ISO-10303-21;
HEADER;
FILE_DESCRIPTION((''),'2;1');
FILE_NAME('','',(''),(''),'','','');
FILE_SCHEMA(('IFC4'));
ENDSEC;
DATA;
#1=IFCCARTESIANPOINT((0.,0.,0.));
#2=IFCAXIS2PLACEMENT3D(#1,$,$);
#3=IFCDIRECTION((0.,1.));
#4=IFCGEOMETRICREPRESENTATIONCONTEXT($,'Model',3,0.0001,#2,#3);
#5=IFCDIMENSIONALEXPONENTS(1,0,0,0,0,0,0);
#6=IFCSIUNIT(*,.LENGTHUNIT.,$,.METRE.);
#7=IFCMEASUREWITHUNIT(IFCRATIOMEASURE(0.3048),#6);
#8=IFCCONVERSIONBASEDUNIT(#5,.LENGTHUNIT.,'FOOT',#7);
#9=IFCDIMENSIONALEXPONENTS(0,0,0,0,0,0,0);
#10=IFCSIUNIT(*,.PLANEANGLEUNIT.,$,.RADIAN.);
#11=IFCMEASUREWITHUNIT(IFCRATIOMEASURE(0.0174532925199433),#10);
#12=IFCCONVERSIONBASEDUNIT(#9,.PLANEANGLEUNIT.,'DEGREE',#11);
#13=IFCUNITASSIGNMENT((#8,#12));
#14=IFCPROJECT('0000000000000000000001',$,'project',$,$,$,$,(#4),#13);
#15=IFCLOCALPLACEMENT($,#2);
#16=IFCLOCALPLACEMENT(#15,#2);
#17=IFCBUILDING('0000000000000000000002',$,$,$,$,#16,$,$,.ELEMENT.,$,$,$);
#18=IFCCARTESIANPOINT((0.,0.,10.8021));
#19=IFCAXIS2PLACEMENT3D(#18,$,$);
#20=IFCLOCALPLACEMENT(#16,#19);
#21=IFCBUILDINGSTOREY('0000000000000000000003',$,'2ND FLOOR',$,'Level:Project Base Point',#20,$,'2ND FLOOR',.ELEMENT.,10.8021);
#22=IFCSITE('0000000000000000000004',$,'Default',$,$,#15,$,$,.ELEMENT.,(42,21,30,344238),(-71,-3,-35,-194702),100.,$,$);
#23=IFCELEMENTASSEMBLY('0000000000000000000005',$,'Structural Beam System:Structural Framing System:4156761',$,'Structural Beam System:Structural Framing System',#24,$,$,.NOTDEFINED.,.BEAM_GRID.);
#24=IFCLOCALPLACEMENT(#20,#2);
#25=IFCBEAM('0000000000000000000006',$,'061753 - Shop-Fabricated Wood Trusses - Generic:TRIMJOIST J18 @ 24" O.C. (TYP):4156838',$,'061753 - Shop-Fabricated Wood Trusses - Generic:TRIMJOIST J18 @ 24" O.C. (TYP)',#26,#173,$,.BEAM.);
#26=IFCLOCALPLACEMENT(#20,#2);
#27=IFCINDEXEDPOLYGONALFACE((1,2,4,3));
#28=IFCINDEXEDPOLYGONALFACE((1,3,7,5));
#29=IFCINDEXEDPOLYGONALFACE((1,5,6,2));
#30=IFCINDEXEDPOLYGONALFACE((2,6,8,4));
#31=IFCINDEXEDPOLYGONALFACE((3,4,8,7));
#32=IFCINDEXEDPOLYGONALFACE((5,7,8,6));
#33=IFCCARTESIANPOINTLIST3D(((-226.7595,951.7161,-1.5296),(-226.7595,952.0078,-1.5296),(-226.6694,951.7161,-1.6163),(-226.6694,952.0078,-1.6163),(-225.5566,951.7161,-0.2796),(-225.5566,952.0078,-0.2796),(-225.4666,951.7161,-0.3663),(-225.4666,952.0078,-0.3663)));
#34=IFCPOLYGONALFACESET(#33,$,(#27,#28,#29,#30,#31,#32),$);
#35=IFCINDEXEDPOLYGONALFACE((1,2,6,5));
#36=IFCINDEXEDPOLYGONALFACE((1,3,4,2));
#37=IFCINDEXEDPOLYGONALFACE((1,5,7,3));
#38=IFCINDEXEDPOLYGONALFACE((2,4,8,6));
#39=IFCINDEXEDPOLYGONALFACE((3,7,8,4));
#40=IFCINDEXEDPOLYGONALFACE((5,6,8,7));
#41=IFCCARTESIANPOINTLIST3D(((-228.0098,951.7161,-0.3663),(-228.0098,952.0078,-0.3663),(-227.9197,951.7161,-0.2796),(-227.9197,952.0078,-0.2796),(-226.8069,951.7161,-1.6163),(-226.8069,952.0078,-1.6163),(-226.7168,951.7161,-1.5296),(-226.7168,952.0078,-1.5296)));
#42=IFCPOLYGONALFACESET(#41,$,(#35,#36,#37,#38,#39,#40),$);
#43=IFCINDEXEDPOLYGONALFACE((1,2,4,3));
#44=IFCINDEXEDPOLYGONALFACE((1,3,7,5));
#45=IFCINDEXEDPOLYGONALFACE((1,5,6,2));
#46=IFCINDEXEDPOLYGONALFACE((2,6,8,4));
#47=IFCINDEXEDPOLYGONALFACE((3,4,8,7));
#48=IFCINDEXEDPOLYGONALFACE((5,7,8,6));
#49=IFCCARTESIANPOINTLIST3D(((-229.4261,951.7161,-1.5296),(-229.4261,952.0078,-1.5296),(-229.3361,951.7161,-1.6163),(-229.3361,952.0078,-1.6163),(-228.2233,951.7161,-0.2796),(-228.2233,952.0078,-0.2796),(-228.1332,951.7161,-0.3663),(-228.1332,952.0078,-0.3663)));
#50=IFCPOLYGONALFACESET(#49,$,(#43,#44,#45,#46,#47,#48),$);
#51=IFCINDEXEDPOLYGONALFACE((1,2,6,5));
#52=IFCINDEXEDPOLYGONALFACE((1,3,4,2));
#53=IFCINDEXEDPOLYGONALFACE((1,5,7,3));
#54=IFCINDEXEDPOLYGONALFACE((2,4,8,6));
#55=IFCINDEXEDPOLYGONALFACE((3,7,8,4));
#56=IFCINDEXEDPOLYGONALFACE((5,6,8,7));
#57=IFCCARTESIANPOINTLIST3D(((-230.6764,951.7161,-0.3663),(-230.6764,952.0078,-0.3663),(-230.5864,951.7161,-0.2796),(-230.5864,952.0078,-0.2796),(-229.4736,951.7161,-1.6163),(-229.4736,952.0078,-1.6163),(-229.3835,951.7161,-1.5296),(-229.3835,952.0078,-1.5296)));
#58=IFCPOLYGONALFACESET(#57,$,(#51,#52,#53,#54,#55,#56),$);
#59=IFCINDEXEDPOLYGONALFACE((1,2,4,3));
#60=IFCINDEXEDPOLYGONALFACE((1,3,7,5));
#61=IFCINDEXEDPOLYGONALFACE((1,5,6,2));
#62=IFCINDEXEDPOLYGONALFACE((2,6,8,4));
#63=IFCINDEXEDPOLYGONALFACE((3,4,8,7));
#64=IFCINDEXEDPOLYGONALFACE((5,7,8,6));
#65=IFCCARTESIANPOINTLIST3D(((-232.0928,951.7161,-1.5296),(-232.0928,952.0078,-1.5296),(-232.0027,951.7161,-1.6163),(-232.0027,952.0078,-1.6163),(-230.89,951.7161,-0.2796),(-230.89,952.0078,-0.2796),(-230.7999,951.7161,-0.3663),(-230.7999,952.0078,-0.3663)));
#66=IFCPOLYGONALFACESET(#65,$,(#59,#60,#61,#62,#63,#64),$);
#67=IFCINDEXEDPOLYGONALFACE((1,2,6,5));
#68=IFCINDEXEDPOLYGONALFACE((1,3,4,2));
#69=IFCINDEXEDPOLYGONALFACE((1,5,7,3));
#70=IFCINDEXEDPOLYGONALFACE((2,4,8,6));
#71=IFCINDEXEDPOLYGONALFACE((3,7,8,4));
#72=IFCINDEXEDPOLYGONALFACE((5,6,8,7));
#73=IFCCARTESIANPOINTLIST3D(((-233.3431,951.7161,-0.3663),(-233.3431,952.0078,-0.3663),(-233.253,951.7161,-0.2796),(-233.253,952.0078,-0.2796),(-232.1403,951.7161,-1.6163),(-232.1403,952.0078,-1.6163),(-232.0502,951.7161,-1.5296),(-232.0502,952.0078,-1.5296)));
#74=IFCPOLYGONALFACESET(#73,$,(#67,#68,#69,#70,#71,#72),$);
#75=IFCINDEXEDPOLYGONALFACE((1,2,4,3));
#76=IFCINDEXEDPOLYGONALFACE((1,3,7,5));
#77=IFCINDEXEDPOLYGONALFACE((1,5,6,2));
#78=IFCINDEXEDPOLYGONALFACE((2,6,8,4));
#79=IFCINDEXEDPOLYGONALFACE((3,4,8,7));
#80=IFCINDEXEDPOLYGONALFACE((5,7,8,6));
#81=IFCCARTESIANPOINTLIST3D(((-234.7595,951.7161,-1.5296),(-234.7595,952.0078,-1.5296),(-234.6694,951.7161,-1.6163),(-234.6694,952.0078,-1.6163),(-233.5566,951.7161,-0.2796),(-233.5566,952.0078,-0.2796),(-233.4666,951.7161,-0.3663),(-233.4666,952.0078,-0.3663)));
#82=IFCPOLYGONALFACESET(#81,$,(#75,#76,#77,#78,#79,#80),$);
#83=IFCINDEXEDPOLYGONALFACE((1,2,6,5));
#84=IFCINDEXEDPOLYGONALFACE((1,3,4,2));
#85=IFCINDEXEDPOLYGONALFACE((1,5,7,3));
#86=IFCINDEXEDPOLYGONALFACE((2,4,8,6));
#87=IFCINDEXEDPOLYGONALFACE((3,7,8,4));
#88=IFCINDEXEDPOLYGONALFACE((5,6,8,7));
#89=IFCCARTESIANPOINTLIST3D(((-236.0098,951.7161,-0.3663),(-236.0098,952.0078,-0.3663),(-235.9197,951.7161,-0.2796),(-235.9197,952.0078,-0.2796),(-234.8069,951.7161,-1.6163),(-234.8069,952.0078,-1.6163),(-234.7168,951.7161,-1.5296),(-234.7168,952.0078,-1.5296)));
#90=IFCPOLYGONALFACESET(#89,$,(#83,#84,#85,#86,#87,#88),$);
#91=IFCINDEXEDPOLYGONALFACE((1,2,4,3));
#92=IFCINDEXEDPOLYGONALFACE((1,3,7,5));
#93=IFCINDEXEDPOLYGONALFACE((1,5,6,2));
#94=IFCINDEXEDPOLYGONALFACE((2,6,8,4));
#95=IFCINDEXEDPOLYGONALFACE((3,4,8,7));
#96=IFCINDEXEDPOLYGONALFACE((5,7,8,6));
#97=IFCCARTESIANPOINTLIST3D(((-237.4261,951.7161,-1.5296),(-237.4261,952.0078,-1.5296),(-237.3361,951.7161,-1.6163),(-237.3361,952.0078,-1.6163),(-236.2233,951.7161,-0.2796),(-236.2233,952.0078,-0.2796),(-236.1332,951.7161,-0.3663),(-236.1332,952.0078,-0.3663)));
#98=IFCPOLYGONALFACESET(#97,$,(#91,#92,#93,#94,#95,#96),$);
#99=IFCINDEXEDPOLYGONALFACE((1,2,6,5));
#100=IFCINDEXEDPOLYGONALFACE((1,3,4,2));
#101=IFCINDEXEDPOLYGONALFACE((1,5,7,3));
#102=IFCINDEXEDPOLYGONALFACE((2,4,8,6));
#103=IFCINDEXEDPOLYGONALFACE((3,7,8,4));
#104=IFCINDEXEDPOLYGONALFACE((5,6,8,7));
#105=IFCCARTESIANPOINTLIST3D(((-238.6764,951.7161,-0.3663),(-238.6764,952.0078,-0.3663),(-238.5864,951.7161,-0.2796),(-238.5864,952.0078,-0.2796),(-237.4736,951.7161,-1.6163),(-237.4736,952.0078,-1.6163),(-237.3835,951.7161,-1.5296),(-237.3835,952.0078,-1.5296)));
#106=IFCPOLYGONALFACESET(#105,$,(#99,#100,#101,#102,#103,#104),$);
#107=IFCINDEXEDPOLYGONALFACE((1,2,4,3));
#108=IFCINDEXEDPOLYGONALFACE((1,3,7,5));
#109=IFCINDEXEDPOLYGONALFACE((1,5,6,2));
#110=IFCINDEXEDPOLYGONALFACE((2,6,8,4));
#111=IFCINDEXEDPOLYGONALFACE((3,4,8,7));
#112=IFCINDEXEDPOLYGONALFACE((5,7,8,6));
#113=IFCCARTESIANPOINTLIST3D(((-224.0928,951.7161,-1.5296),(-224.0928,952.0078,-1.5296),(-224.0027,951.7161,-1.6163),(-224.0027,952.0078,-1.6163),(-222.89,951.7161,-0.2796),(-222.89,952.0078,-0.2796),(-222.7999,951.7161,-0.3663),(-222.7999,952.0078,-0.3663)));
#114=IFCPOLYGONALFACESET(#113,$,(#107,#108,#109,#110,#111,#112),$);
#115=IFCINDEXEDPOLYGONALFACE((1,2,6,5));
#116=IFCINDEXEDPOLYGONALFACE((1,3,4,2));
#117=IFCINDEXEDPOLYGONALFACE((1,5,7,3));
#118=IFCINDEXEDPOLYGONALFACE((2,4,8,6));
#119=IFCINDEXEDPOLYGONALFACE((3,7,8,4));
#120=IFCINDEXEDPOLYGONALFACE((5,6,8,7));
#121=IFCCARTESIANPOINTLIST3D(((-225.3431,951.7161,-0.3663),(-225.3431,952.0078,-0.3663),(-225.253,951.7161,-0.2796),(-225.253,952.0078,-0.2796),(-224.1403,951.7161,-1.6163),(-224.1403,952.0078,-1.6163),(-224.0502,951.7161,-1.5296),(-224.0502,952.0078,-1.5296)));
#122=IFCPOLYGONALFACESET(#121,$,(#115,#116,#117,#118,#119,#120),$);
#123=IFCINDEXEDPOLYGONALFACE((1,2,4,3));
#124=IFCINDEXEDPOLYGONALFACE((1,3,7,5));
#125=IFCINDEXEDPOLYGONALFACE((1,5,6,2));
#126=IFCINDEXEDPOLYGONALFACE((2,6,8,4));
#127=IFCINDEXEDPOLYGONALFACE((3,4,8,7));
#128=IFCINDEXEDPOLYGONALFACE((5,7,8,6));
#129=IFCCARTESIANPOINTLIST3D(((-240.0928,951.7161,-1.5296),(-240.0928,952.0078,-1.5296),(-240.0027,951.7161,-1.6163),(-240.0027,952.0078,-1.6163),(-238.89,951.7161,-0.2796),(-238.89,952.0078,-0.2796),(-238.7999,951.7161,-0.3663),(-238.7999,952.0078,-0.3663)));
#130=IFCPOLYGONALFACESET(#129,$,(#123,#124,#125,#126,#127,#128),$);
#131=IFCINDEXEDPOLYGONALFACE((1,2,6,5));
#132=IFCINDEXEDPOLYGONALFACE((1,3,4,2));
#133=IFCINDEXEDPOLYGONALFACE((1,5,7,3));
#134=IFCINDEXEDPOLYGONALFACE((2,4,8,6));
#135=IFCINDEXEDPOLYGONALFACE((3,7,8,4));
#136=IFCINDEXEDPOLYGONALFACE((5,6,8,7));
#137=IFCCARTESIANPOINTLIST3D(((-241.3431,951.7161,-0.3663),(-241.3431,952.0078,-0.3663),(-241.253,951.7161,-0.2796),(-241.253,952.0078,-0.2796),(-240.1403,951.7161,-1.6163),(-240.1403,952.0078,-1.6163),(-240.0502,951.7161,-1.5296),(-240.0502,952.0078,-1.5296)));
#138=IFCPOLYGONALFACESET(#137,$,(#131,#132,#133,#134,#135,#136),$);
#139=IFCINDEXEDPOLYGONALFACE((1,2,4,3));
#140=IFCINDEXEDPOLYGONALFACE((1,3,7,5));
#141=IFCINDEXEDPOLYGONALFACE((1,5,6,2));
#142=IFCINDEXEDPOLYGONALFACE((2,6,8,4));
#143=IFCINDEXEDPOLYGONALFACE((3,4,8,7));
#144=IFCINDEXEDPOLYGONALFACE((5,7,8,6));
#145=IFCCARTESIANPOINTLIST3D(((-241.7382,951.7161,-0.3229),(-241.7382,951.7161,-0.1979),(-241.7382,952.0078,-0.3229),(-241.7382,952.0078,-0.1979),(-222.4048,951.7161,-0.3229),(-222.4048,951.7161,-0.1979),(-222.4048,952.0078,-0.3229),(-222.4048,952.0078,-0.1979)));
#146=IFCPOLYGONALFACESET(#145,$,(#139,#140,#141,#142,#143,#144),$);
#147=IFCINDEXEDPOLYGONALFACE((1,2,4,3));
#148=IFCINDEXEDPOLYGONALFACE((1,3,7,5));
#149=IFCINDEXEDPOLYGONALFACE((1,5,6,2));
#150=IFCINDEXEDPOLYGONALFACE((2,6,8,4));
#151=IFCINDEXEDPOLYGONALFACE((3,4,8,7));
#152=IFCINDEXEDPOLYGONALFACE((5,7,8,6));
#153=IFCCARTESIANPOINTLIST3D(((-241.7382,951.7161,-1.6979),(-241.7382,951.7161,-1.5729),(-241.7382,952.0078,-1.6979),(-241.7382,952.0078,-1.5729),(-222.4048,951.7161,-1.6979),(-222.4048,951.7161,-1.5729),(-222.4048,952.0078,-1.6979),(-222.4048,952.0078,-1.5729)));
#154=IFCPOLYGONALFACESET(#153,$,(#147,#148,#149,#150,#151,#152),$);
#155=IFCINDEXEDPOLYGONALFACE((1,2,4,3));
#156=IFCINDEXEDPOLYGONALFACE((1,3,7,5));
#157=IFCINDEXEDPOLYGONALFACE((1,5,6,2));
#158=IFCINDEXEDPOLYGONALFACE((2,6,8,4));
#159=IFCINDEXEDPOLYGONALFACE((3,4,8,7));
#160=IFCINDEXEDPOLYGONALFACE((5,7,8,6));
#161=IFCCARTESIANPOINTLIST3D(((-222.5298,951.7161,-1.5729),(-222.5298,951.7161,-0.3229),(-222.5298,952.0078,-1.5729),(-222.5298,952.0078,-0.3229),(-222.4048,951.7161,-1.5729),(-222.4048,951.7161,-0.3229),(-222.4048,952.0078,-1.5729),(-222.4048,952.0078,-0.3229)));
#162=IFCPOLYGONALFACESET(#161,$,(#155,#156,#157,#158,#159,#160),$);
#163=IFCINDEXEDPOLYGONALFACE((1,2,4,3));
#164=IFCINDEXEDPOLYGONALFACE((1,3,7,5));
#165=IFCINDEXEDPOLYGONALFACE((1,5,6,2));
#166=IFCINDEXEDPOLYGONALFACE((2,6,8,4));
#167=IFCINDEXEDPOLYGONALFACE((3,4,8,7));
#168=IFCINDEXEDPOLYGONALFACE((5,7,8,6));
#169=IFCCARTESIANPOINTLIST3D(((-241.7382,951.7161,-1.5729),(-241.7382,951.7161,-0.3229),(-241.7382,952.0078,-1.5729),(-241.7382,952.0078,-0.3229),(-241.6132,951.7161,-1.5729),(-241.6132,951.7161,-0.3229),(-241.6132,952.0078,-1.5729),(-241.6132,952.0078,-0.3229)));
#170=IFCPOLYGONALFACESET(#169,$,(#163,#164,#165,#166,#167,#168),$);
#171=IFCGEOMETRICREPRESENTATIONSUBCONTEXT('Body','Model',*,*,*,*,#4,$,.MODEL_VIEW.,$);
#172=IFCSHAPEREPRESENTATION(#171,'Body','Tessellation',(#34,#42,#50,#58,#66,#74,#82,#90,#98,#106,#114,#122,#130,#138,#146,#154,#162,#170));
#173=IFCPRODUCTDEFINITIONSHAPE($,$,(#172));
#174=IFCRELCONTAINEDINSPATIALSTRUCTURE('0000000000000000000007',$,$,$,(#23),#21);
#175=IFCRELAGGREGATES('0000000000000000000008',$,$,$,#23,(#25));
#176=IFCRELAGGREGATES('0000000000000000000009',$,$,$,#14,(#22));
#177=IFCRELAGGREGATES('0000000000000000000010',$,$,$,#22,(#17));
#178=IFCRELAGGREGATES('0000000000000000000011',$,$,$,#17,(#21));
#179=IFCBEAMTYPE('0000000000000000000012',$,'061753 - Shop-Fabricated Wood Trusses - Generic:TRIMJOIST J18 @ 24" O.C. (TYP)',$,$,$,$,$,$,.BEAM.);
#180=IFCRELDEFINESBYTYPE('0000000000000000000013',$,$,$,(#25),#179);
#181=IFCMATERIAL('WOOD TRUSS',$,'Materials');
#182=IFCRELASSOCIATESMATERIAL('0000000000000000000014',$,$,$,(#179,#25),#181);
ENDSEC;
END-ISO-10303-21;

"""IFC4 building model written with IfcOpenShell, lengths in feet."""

from ifc_helpers import new_model, entity, si_unit, converted_unit, direction, frame, frame_2d, origin, origin_2d_with_axis, place, context, subcontext, project, spatial, rectangle, extrude, source, transform, mapped, material, material_profile, profile_set, profile_usage, type_object, type_shapes, element, aggregate, save


model = new_model("IFC4")

# Units and contexts
model_context = context("Model", 3, precision=0.0001, world=origin(), true_north=direction((0.0, 1.0)))
body_context = subcontext(model_context, "Body", "Model", "MODEL_VIEW")
ifc_project = project(units=[converted_unit("LENGTHUNIT", "FOOT", entity("IfcRatioMeasure", 0.3048), si_unit("LENGTHUNIT", "METRE"), dimensions=[1, 0, 0, 0, 0, 0, 0]), converted_unit("PLANEANGLEUNIT", "DEGREE", entity("IfcRatioMeasure", 0.0174532925199433), si_unit("PLANEANGLEUNIT", "RADIAN"), dimensions=[0, 0, 0, 0, 0, 0, 0])], contexts=[model_context])

# Site, building, storey
site_placement = place(None, origin())
site = spatial("IfcSite", under=ifc_project, at=site_placement, Name="Default", CompositionType="ELEMENT", RefLatitude=(42, 21, 30, 344238), RefLongitude=(-71, -3, -35, -194702), RefElevation=100.0)
building_placement = place(site_placement, origin())
building = spatial("IfcBuilding", under=site, at=building_placement, CompositionType="ELEMENT")
storey_placement = place(building_placement, frame((0.0, 0.0, 10.8021)))
storey = spatial("IfcBuildingStorey", under=building, at=storey_placement, Name="2ND FLOOR", ObjectType="Level:Project Base Point", LongName="2ND FLOOR", CompositionType="ELEMENT", Elevation=10.8021)

# Element assembly, beam
assembly_1_placement = place(storey_placement, origin())
assembly_1 = element("IfcElementAssembly", 1, at=assembly_1_placement, inside=storey, Name="Structural Beam System:Structural Framing System:4156761", ObjectType="Structural Beam System:Structural Framing System", AssemblyPlace="NOTDEFINED", PredefinedType="BEAM_GRID")
ifc_material_1 = material(Name="WOOD TRUSS", Category="Materials")
ifc_material_profile_1 = material_profile(ifc_material_1, rectangle(XDim=1.7347, YDim=0.125, at=frame_2d((0.0, 0.0), x_axis=(1.0, 0.0))), Name="TRIMJOIST J18 @ 24\" O.C. (TYP)")
ifc_material_profile_2 = material_profile(ifc_material_1, rectangle(XDim=1.7347, YDim=0.125, at=frame_2d((0.0, 0.0), x_axis=(1.0, 0.0))), Name="TRIMJOIST J18 @ 24\" O.C. (TYP)")
ifc_material_profile_3 = material_profile(ifc_material_1, rectangle(XDim=1.7347, YDim=0.125, at=frame_2d((0.0, 0.0), x_axis=(1.0, 0.0))), Name="TRIMJOIST J18 @ 24\" O.C. (TYP)")
ifc_material_profile_4 = material_profile(ifc_material_1, rectangle(XDim=1.7347, YDim=0.125, at=frame_2d((0.0, 0.0), x_axis=(1.0, 0.0))), Name="TRIMJOIST J18 @ 24\" O.C. (TYP)")
ifc_material_profile_5 = material_profile(ifc_material_1, rectangle(XDim=1.7347, YDim=0.125, at=frame_2d((0.0, 0.0), x_axis=(1.0, 0.0))), Name="TRIMJOIST J18 @ 24\" O.C. (TYP)")
ifc_material_profile_6 = material_profile(ifc_material_1, rectangle(XDim=1.7347, YDim=0.125, at=frame_2d((0.0, 0.0), x_axis=(1.0, 0.0))), Name="TRIMJOIST J18 @ 24\" O.C. (TYP)")
ifc_material_profile_7 = material_profile(ifc_material_1, rectangle(XDim=1.7347, YDim=0.125, at=frame_2d((0.0, 0.0), x_axis=(1.0, 0.0))), Name="TRIMJOIST J18 @ 24\" O.C. (TYP)")
ifc_material_profile_8 = material_profile(ifc_material_1, rectangle(XDim=1.7347, YDim=0.125, at=frame_2d((0.0, 0.0), x_axis=(1.0, 0.0))), Name="TRIMJOIST J18 @ 24\" O.C. (TYP)")
ifc_material_profile_9 = material_profile(ifc_material_1, rectangle(XDim=1.7347, YDim=0.125, at=frame_2d((0.0, 0.0), x_axis=(1.0, 0.0))), Name="TRIMJOIST J18 @ 24\" O.C. (TYP)")
ifc_material_profile_10 = material_profile(ifc_material_1, rectangle(XDim=1.7347, YDim=0.125, at=origin_2d_with_axis()), Name="TRIMJOIST J18 @ 24\" O.C. (TYP)")
ifc_material_profile_11 = material_profile(ifc_material_1, rectangle(XDim=0.125, YDim=0.2917, at=origin_2d_with_axis()), Name="TRIMJOIST J18 @ 24\" O.C. (TYP)")
ifc_material_profile_12 = material_profile(ifc_material_1, rectangle(XDim=0.125, YDim=0.2917, at=origin_2d_with_axis()), Name="TRIMJOIST J18 @ 24\" O.C. (TYP)")
ifc_material_profile_13 = material_profile(ifc_material_1, rectangle(XDim=1.25, YDim=0.2917, at=origin_2d_with_axis()), Name="TRIMJOIST J18 @ 24\" O.C. (TYP)")
ifc_material_profile_14 = material_profile(ifc_material_1, rectangle(XDim=1.25, YDim=0.2917, at=origin_2d_with_axis()), Name="TRIMJOIST J18 @ 24\" O.C. (TYP)")
ifc_profile_set_1 = profile_set([ifc_material_profile_1, ifc_material_profile_2, ifc_material_profile_3, ifc_material_profile_4, ifc_material_profile_5, ifc_material_profile_6, ifc_material_profile_7, ifc_material_profile_8, ifc_material_profile_9, ifc_material_profile_10, ifc_material_profile_11, ifc_material_profile_12, ifc_material_profile_13, ifc_material_profile_14], Name="TRIMJOIST J18 @ 24\" O.C. (TYP)")
beam_type_1 = type_object("IfcBeamType", Name="061753 - Shop-Fabricated Wood Trusses - Generic:TRIMJOIST J18 @ 24\" O.C. (TYP)", PredefinedType="BEAM", material=ifc_profile_set_1)
shared_shape_1 = source(origin(), body_context, "Body", "SweptSolid", [
    extrude(rectangle(XDim=1.7347, YDim=0.125, at=frame_2d((0.0, 0.0), x_axis=(1.0, 0.0))), frame((5.9585, -0.1458, 0.0), z_axis=(0.0, 1.0, 0.0), x_axis=(0.693383, 0.0, 0.720569)), (0.0, 0.0, 1.0), 0.2917),
    extrude(rectangle(XDim=1.7347, YDim=0.125, at=origin_2d_with_axis()), frame((4.7082, -0.1458, 0.0), z_axis=(0.0, 1.0, 0.0), x_axis=(0.693383, 0.0, -0.720569)), (0.0, 0.0, 1.0), 0.2917),
    extrude(rectangle(XDim=1.7347, YDim=0.125, at=frame_2d((0.0, 0.0), x_axis=(1.0, 0.0))), frame((3.2918, -0.1458, 0.0), z_axis=(0.0, 1.0, 0.0), x_axis=(0.693383, 0.0, 0.720569)), (0.0, 0.0, 1.0), 0.2917),
    extrude(rectangle(XDim=1.7347, YDim=0.125, at=frame_2d((0.0, 0.0), x_axis=(1.0, 0.0))), frame((2.0415, -0.1458, 0.0), z_axis=(0.0, 1.0, 0.0), x_axis=(0.693383, 0.0, -0.720569)), (0.0, 0.0, 1.0), 0.2917),
    extrude(rectangle(XDim=1.7347, YDim=0.125, at=frame_2d((0.0, 0.0), x_axis=(1.0, 0.0))), frame((0.6251, -0.1458, 0.0), z_axis=(0.0, 1.0, 0.0), x_axis=(0.693383, 0.0, 0.720569)), (0.0, 0.0, 1.0), 0.2917),
    extrude(rectangle(XDim=1.7347, YDim=0.125, at=frame_2d((0.0, 0.0), x_axis=(1.0, 0.0))), frame((-0.6251, -0.1458, 0.0), z_axis=(0.0, 1.0, 0.0), x_axis=(0.693383, 0.0, -0.720569)), (0.0, 0.0, 1.0), 0.2917),
    extrude(rectangle(XDim=1.7347, YDim=0.125, at=frame_2d((0.0, 0.0), x_axis=(1.0, 0.0))), frame((-2.0415, -0.1458, 0.0), z_axis=(0.0, 1.0, 0.0), x_axis=(0.693383, 0.0, 0.720569)), (0.0, 0.0, 1.0), 0.2917),
    extrude(rectangle(XDim=1.7347, YDim=0.125, at=origin_2d_with_axis()), frame((-3.2918, -0.1458, 0.0), z_axis=(0.0, 1.0, 0.0), x_axis=(0.693383, 0.0, -0.720569)), (0.0, 0.0, 1.0), 0.2917),
    extrude(rectangle(XDim=1.7347, YDim=0.125, at=frame_2d((0.0, 0.0), x_axis=(1.0, 0.0))), frame((-4.7082, -0.1458, 0.0), z_axis=(0.0, 1.0, 0.0), x_axis=(0.693383, 0.0, 0.720569)), (0.0, 0.0, 1.0), 0.2917),
    extrude(rectangle(XDim=1.7347, YDim=0.125, at=frame_2d((0.0, 0.0), x_axis=(1.0, 0.0))), frame((-5.9585, -0.1458, 0.0), z_axis=(0.0, 1.0, 0.0), x_axis=(0.693383, 0.0, -0.720569)), (0.0, 0.0, 1.0), 0.2917),
    extrude(rectangle(XDim=1.7347, YDim=0.125, at=frame_2d((0.0, 0.0), x_axis=(1.0, 0.0))), frame((8.6251, -0.1458, 0.0), z_axis=(0.0, 1.0, 0.0), x_axis=(0.693383, 0.0, 0.720569)), (0.0, 0.0, 1.0), 0.2917),
    extrude(rectangle(XDim=1.7347, YDim=0.125, at=origin_2d_with_axis()), frame((7.3749, -0.1458, 0.0), z_axis=(0.0, 1.0, 0.0), x_axis=(0.693383, 0.0, -0.720569)), (0.0, 0.0, 1.0), 0.2917),
    extrude(rectangle(XDim=1.7347, YDim=0.125, at=frame_2d((0.0, 0.0), x_axis=(1.0, 0.0))), frame((-7.3749, -0.1458, 0.0), z_axis=(0.0, 1.0, 0.0), x_axis=(0.693383, 0.0, 0.720569)), (0.0, 0.0, 1.0), 0.2917),
    extrude(rectangle(XDim=1.7347, YDim=0.125, at=origin_2d_with_axis()), frame((-8.6251, -0.1458, 0.0), z_axis=(0.0, 1.0, 0.0), x_axis=(0.693383, 0.0, -0.720569)), (0.0, 0.0, 1.0), 0.2917),
    extrude(rectangle(XDim=0.125, YDim=0.2917, at=origin_2d_with_axis()), frame((-9.6667, 0.0, 0.6875), z_axis=(1.0, 0.0, 0.0), x_axis=(0.0, 0.0, -1.0)), (0.0, 0.0, 1.0), 19.3333),
    extrude(rectangle(XDim=0.125, YDim=0.2917, at=origin_2d_with_axis()), frame((-9.6667, 0.0, -0.6875), z_axis=(1.0, 0.0, 0.0), x_axis=(0.0, 0.0, -1.0)), (0.0, 0.0, 1.0), 19.3333),
    extrude(rectangle(XDim=1.25, YDim=0.2917, at=origin_2d_with_axis()), frame((9.5417, 0.0, 0.0), z_axis=(1.0, 0.0, 0.0), x_axis=(0.0, 0.0, -1.0)), (0.0, 0.0, 1.0), 0.125),
    extrude(rectangle(XDim=1.25, YDim=0.2917, at=origin_2d_with_axis()), frame((-9.6667, 0.0, 0.0), z_axis=(1.0, 0.0, 0.0), x_axis=(0.0, 0.0, -1.0)), (0.0, 0.0, 1.0), 0.125),
])
type_shapes(beam_type_1, [shared_shape_1])
ifc_profile_usage_1 = profile_usage(ifc_profile_set_1, cardinal=8)
beam_1_placement = place(assembly_1_placement, frame((-232.0715, 951.8619, -0.9479)))
beam_1 = element("IfcBeam", 2, at=beam_1_placement, type_object=beam_type_1, material=ifc_profile_usage_1, Name="061753 - Shop-Fabricated Wood Trusses - Generic:TRIMJOIST J18 @ 24\" O.C. (TYP):4156838", ObjectType="061753 - Shop-Fabricated Wood Trusses - Generic:TRIMJOIST J18 @ 24\" O.C. (TYP)", PredefinedType="BEAM", context=body_context, shape_type="MappedRepresentation", body=[
    mapped(shared_shape_1, transform((0.0, 0.0, 0.0), scale=1.0)),
])
aggregate(assembly_1, [beam_1])

save(model, "model.ifc")
